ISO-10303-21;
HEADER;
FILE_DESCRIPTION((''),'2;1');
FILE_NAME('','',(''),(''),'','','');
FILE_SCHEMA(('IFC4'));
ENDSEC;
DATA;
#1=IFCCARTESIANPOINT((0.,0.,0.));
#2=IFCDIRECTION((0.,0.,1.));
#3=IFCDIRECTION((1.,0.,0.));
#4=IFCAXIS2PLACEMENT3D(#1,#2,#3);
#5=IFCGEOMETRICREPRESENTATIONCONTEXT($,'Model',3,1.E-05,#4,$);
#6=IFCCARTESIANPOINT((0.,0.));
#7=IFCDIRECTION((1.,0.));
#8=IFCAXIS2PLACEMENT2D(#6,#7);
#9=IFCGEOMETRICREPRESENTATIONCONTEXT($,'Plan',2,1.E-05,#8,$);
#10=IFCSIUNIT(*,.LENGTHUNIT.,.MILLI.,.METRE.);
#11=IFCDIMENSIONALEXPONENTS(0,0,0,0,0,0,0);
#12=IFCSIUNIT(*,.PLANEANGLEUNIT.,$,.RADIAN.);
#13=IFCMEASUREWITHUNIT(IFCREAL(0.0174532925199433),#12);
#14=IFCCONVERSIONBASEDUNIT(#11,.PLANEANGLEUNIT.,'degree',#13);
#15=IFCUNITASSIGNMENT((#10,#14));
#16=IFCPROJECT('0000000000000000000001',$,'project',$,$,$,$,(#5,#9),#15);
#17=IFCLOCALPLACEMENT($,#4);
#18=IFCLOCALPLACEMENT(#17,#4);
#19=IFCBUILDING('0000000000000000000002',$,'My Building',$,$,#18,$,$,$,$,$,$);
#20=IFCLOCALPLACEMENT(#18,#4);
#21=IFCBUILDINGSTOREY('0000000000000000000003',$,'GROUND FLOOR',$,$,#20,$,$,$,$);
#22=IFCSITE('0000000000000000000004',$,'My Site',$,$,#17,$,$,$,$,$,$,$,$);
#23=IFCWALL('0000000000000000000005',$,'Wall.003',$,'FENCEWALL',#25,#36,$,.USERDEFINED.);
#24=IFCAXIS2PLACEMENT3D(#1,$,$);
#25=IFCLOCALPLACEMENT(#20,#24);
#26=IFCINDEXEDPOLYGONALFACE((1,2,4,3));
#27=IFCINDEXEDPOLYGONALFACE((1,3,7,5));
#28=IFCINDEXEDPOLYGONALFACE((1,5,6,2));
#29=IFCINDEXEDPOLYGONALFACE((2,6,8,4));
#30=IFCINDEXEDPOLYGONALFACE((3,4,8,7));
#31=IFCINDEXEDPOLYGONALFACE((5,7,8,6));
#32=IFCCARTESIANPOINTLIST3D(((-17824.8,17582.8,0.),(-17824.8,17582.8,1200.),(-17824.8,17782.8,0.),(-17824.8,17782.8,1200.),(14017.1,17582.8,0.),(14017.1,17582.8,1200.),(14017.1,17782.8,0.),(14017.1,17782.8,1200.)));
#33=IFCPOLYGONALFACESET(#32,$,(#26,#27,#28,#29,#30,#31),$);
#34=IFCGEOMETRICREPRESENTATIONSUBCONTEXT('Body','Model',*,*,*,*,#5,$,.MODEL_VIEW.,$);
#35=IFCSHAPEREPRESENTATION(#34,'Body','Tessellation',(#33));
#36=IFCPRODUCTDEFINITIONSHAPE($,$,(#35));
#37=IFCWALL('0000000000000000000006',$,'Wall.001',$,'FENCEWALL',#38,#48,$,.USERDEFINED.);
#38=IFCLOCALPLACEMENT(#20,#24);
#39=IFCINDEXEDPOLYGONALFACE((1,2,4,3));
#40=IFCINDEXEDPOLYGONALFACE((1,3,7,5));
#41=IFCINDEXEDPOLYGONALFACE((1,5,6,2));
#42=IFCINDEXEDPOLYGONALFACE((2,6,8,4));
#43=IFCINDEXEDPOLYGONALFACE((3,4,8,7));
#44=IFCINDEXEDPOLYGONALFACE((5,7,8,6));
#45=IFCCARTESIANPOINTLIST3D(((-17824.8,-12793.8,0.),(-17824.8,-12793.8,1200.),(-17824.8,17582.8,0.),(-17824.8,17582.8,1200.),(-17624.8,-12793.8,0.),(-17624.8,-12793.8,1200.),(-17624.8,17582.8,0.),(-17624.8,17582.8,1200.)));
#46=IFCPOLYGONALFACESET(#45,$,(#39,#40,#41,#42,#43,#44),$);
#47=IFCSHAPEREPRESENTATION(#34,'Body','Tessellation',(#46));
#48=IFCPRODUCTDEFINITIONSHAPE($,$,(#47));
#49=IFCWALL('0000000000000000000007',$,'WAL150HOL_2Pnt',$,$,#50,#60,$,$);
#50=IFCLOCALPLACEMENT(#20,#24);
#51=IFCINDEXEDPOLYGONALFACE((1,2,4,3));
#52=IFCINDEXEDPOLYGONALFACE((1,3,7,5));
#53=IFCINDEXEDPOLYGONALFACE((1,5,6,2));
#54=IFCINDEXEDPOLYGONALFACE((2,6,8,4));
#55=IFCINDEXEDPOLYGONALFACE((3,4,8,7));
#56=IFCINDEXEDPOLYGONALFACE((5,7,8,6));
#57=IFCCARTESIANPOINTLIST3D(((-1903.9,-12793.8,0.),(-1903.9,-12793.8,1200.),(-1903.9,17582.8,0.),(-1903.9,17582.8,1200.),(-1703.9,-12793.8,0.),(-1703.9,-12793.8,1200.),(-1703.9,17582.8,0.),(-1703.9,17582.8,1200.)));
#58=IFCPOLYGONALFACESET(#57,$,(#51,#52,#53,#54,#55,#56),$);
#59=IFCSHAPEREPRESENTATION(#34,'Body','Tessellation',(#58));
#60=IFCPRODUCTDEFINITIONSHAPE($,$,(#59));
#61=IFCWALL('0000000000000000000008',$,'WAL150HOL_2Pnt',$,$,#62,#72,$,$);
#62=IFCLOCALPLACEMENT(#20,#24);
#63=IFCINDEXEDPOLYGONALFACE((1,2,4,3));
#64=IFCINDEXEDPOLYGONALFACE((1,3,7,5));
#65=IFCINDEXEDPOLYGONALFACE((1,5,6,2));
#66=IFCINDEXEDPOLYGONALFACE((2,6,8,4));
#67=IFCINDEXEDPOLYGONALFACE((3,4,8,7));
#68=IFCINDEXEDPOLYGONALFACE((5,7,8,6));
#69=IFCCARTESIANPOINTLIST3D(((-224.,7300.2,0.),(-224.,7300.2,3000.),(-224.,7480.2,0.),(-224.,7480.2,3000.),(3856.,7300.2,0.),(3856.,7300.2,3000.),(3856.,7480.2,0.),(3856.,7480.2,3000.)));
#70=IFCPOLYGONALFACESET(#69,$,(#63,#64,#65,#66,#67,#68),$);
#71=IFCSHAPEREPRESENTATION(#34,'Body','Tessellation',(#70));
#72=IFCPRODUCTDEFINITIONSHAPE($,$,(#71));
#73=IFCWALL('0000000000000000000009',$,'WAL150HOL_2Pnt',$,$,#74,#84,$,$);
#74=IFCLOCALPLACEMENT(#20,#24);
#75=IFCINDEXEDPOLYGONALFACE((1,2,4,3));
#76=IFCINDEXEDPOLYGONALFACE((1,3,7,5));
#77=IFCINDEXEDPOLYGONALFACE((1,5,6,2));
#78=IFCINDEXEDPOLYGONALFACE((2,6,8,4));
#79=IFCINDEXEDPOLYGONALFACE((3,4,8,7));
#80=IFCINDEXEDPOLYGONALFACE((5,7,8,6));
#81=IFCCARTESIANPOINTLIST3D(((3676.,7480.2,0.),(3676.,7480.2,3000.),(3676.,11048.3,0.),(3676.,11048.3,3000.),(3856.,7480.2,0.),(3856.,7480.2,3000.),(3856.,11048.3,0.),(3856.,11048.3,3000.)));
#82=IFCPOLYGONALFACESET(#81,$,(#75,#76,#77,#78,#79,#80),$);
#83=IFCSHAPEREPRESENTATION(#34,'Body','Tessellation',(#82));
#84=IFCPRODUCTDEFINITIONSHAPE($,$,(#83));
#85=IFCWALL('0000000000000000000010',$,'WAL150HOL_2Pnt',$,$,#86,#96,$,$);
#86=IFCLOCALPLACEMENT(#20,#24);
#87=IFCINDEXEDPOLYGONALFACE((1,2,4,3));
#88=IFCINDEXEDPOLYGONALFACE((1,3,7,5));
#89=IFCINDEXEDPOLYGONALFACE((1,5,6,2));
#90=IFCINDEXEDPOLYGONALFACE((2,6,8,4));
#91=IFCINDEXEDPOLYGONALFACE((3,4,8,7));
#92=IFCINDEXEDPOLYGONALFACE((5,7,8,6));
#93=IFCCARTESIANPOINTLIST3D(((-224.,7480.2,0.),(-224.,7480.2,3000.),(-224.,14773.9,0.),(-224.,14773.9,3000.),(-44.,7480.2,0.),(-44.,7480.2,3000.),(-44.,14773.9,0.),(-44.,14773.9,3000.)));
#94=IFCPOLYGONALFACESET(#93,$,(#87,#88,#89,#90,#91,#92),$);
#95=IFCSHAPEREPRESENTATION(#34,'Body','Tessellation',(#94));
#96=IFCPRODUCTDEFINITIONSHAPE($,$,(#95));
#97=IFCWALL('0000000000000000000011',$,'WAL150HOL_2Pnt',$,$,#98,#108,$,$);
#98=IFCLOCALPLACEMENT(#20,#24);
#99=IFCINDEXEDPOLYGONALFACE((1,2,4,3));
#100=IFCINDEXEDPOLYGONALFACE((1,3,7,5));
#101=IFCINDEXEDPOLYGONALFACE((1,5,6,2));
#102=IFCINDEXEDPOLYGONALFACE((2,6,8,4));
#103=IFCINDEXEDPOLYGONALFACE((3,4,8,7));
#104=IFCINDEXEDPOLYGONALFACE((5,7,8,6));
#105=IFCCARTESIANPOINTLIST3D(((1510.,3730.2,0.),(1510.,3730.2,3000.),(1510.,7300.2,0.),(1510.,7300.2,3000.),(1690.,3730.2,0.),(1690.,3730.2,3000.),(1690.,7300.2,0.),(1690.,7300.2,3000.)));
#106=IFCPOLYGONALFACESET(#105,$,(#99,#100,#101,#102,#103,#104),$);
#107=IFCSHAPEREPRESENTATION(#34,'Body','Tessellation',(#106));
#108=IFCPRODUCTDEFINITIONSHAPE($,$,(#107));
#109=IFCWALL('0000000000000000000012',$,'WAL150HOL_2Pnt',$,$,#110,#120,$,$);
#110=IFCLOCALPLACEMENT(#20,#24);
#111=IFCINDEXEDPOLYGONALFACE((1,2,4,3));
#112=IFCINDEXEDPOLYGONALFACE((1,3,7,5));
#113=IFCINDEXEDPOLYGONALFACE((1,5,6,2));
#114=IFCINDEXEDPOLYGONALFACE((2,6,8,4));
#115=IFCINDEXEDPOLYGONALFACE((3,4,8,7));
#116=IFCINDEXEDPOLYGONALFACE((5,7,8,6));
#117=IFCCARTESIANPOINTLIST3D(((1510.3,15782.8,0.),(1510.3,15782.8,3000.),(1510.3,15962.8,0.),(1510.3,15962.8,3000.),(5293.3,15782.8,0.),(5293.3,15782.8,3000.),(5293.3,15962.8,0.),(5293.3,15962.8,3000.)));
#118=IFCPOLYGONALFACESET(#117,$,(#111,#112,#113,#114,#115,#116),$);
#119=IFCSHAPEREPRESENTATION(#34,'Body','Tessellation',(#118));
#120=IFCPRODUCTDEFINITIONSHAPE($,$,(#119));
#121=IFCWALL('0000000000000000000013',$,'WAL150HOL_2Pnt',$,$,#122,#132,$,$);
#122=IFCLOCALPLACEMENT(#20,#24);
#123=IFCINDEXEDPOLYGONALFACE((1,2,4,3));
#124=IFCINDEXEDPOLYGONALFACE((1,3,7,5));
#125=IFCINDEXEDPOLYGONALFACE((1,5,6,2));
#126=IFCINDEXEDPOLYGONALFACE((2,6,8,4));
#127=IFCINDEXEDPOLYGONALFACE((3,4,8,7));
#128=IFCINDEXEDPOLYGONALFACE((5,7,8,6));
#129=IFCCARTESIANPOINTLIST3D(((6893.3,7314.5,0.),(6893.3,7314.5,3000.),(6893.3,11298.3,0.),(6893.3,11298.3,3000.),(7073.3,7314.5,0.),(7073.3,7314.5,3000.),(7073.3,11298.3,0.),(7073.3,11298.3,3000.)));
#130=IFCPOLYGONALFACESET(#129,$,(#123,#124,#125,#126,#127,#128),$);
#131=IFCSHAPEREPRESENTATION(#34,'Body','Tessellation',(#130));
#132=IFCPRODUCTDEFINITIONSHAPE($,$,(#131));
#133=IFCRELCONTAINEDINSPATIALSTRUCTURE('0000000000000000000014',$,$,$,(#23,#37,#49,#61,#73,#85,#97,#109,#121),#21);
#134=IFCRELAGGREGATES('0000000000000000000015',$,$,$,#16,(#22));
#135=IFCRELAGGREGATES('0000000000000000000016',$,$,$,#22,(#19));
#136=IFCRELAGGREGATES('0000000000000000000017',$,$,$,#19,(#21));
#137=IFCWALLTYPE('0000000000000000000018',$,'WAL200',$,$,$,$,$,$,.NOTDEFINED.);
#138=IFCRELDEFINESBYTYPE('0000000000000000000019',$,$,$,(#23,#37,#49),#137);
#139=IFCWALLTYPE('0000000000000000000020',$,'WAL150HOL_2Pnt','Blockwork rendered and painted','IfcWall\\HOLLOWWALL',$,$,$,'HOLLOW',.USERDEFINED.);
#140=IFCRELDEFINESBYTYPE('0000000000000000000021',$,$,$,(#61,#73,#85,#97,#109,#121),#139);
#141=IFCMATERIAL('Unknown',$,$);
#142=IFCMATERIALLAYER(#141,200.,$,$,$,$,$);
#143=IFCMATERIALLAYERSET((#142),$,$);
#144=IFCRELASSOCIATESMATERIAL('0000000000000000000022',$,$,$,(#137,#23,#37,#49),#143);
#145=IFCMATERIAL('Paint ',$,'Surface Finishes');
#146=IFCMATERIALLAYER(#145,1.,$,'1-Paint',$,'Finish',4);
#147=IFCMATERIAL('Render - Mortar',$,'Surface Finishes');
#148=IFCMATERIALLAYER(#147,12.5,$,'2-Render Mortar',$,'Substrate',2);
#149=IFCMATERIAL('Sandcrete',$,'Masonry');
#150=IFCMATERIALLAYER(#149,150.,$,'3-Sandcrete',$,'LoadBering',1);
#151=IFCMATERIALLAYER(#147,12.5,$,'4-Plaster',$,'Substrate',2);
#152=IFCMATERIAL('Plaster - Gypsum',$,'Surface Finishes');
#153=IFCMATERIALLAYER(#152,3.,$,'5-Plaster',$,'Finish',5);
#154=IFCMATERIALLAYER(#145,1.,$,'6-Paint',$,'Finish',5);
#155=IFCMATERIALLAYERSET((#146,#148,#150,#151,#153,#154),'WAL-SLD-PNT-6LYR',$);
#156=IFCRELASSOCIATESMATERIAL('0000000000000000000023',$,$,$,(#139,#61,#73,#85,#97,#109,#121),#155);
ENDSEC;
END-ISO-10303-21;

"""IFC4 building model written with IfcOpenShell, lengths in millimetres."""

from ifc_helpers import new_model, entity, si_unit, converted_unit, frame, origin_with_axes, origin_2d_with_axis, place, context, subcontext, project, spatial, indexed_curve, outline, extrude, material, layer, layer_set, layer_usage, type_object, element, save


model = new_model("IFC4")

# Units and contexts
model_context = context("Model", 3, precision=1e-05, world=origin_with_axes())
plan_context = context("Plan", 2, precision=1e-05, world=origin_2d_with_axis())
body_context_1 = subcontext(model_context, "Body", "Model", "MODEL_VIEW")
ifc_project = project(units=[si_unit("LENGTHUNIT", "METRE", prefix="MILLI"), converted_unit("PLANEANGLEUNIT", "degree", entity("IfcReal", 0.0174532925199433), si_unit("PLANEANGLEUNIT", "RADIAN"), dimensions=[0, 0, 0, 0, 0, 0, 0])], contexts=[model_context, plan_context])

# Site, building, storey
site_placement = place(None, origin_with_axes())
site = spatial("IfcSite", under=ifc_project, at=site_placement, Name="My Site")
building_placement = place(site_placement, origin_with_axes())
building = spatial("IfcBuilding", under=site, at=building_placement, Name="My Building")
storey_placement = place(building_placement, origin_with_axes())
storey = spatial("IfcBuildingStorey", under=building, at=storey_placement, Name="GROUND FLOOR")

# Walls
ifc_material_1 = material(Name="Unknown")
ifc_layer_1 = layer(ifc_material_1, 200.0)
ifc_layer_set_1 = layer_set([ifc_layer_1])
ifc_layer_usage_1 = layer_usage(ifc_layer_set_1, "AXIS2", "POSITIVE", 0.0)
wall_type_1 = type_object("IfcWallType", Name="WAL200", PredefinedType="NOTDEFINED", material=ifc_layer_set_1)
wall_1_placement = place(storey_placement, frame((-17824.8, 17582.8, 0.0), z_axis=(0.0, 0.0, 1.0), x_axis=(1.0, 0.0, 0.0)))
element("IfcWall", 1, at=wall_1_placement, inside=storey, type_object=wall_type_1, material=ifc_layer_usage_1, Name="Wall.003", ObjectType="FENCEWALL", PredefinedType="USERDEFINED", context=body_context_1, shape_type="SweptSolid", body=[
    extrude(outline(indexed_curve([(0.0, 0.0), (0.0, 200.0), (31841.9, 200.0), (31841.9, 0.0), (0.0, 0.0)], self_intersect=False)), origin_with_axes(), (0.0, 0.0, 1.0), 1200.0),
])
ifc_layer_usage_2 = layer_usage(ifc_layer_set_1, "AXIS2", "POSITIVE", 0.0)
wall_2_placement = place(storey_placement, frame((-17824.8, 17582.8, 0.0), z_axis=(0.0, 0.0, 1.0), x_axis=(-0.000001, -1.0, 0.0)))
element("IfcWall", 2, at=wall_2_placement, inside=storey, type_object=wall_type_1, material=ifc_layer_usage_2, Name="Wall.001", ObjectType="FENCEWALL", PredefinedType="USERDEFINED", context=body_context_1, shape_type="SweptSolid", body=[
    extrude(outline(indexed_curve([(0.0, 0.0), (0.0, 200.0), (30376.6, 200.0), (30376.6, 0.0), (0.0, 0.0)], self_intersect=False)), origin_with_axes(), (0.0, 0.0, 1.0), 1200.0),
])
ifc_layer_usage_3 = layer_usage(ifc_layer_set_1, "AXIS2", "POSITIVE", 0.0)
wall_3_placement = place(storey_placement, frame((-1903.9, 17582.8, 0.0), z_axis=(0.0, 0.0, 1.0), x_axis=(-0.000001, -1.0, 0.0)))
element("IfcWall", 3, at=wall_3_placement, inside=storey, type_object=wall_type_1, material=ifc_layer_usage_3, Name="WAL150HOL_2Pnt", context=body_context_1, shape_type="SweptSolid", body=[
    extrude(outline(indexed_curve([(0.0, 0.0), (0.0, 200.0), (30376.6, 200.0), (30376.6, 0.0), (0.0, 0.0)], self_intersect=False)), origin_with_axes(), (0.0, 0.0, 1.0), 1200.0),
])
ifc_material_2 = material(Name="Paint ", Category="Surface Finishes")
ifc_layer_2 = layer(ifc_material_2, 1.0, Name="1-Paint", Category="Finish", Priority=4)
ifc_material_3 = material(Name="Render - Mortar", Category="Surface Finishes")
ifc_layer_3 = layer(ifc_material_3, 12.5, Name="2-Render Mortar", Category="Substrate", Priority=2)
ifc_material_4 = material(Name="Sandcrete", Category="Masonry")
ifc_layer_4 = layer(ifc_material_4, 150.0, Name="3-Sandcrete", Category="LoadBering", Priority=1)
ifc_layer_5 = layer(ifc_material_3, 12.5, Name="4-Plaster", Category="Substrate", Priority=2)
ifc_material_5 = material(Name="Plaster - Gypsum", Category="Surface Finishes")
ifc_layer_6 = layer(ifc_material_5, 3.0, Name="5-Plaster", Category="Finish", Priority=5)
ifc_layer_7 = layer(ifc_material_2, 1.0, Name="6-Paint", Category="Finish", Priority=5)
ifc_layer_set_2 = layer_set([ifc_layer_2, ifc_layer_3, ifc_layer_4, ifc_layer_5, ifc_layer_6, ifc_layer_7], Name="WAL-SLD-PNT-6LYR")
ifc_layer_usage_4 = layer_usage(ifc_layer_set_2, "AXIS2", "POSITIVE", 0.0)
wall_type_2 = type_object("IfcWallType", Name="WAL150HOL_2Pnt", Description="Blockwork rendered and painted", ApplicableOccurrence="IfcWall\\HOLLOWWALL", ElementType="HOLLOW", PredefinedType="USERDEFINED", material=ifc_layer_set_2)
wall_4_placement = place(storey_placement, frame((-224.0, 7300.2, 0.0), z_axis=(0.0, 0.0, 1.0), x_axis=(1.0, 0.0, 0.0)))
element("IfcWall", 4, at=wall_4_placement, inside=storey, type_object=wall_type_2, material=ifc_layer_usage_4, Name="WAL150HOL_2Pnt", context=body_context_1, shape_type="SweptSolid", body=[
    extrude(outline(indexed_curve([(0.0, 0.0), (0.0, 180.0), (4080.0, 180.0), (4080.0, 0.0), (0.0, 0.0)], self_intersect=False)), origin_with_axes(), (0.0, 0.0, 1.0), 3000.0),
])
ifc_layer_usage_5 = layer_usage(ifc_layer_set_2, "AXIS2", "POSITIVE", 0.0)
wall_5_placement = place(storey_placement, frame((3856.0, 7480.2, 0.0), z_axis=(0.0, 0.0, 1.0), x_axis=(0.0, 1.0, 0.0)))
element("IfcWall", 5, at=wall_5_placement, inside=storey, type_object=wall_type_2, material=ifc_layer_usage_5, Name="WAL150HOL_2Pnt", context=body_context_1, shape_type="SweptSolid", body=[
    extrude(outline(indexed_curve([(0.0, 0.0), (0.0, 180.0), (3568.1, 180.0), (3568.1, 0.0), (0.0, 0.0)], self_intersect=False)), origin_with_axes(), (0.0, 0.0, 1.0), 3000.0),
])
ifc_layer_usage_6 = layer_usage(ifc_layer_set_2, "AXIS2", "POSITIVE", 0.0)
wall_6_placement = place(storey_placement, frame((-224.0, 14773.9, 0.0), z_axis=(0.0, 0.0, 1.0), x_axis=(0.0, -1.0, 0.0)))
element("IfcWall", 6, at=wall_6_placement, inside=storey, type_object=wall_type_2, material=ifc_layer_usage_6, Name="WAL150HOL_2Pnt", context=body_context_1, shape_type="SweptSolid", body=[
    extrude(outline(indexed_curve([(0.0, 0.0), (0.0, 180.0), (7293.8, 180.0), (7293.8, 0.0), (0.0, 0.0)], self_intersect=False)), origin_with_axes(), (0.0, 0.0, 1.0), 3000.0),
])
ifc_layer_usage_7 = layer_usage(ifc_layer_set_2, "AXIS2", "POSITIVE", 0.0)
wall_7_placement = place(storey_placement, frame((1510.0, 7300.2, 0.0), z_axis=(0.0, 0.0, 1.0), x_axis=(-0.000001, -1.0, 0.0)))
element("IfcWall", 7, at=wall_7_placement, inside=storey, type_object=wall_type_2, material=ifc_layer_usage_7, Name="WAL150HOL_2Pnt", context=body_context_1, shape_type="SweptSolid", body=[
    extrude(outline(indexed_curve([(0.0, 0.0), (0.0, 180.0), (3570.0, 180.0), (3570.0, 0.0), (0.0, 0.0)], self_intersect=False)), origin_with_axes(), (0.0, 0.0, 1.0), 3000.0),
])
ifc_layer_usage_8 = layer_usage(ifc_layer_set_2, "AXIS2", "POSITIVE", 0.0)
wall_8_placement = place(storey_placement, frame((5293.3, 15962.8, 0.0), z_axis=(0.0, 0.0, 1.0), x_axis=(-1.0, 0.000001, 0.0)))
element("IfcWall", 8, at=wall_8_placement, inside=storey, type_object=wall_type_2, material=ifc_layer_usage_8, Name="WAL150HOL_2Pnt", context=body_context_1, shape_type="SweptSolid", body=[
    extrude(outline(indexed_curve([(0.0, 0.0), (0.0, 180.0), (3783.0, 180.0), (3783.0, 0.0), (0.0, 0.0)], self_intersect=False)), origin_with_axes(), (0.0, 0.0, 1.0), 3000.0),
])
ifc_layer_usage_9 = layer_usage(ifc_layer_set_2, "AXIS2", "POSITIVE", 0.0)
wall_9_placement = place(storey_placement, frame((6893.3, 11298.3, 0.0), z_axis=(0.0, 0.0, 1.0), x_axis=(-0.000001, -1.0, 0.0)))
element("IfcWall", 9, at=wall_9_placement, inside=storey, type_object=wall_type_2, material=ifc_layer_usage_9, Name="WAL150HOL_2Pnt", context=body_context_1, shape_type="SweptSolid", body=[
    extrude(outline(indexed_curve([(0.0, 0.0), (0.0, 180.0), (3983.8, 180.0), (3983.8, 0.0), (0.0, 0.0)], self_intersect=False)), origin_with_axes(), (0.0, 0.0, 1.0), 3000.0),
])

save(model, "model.ifc")
